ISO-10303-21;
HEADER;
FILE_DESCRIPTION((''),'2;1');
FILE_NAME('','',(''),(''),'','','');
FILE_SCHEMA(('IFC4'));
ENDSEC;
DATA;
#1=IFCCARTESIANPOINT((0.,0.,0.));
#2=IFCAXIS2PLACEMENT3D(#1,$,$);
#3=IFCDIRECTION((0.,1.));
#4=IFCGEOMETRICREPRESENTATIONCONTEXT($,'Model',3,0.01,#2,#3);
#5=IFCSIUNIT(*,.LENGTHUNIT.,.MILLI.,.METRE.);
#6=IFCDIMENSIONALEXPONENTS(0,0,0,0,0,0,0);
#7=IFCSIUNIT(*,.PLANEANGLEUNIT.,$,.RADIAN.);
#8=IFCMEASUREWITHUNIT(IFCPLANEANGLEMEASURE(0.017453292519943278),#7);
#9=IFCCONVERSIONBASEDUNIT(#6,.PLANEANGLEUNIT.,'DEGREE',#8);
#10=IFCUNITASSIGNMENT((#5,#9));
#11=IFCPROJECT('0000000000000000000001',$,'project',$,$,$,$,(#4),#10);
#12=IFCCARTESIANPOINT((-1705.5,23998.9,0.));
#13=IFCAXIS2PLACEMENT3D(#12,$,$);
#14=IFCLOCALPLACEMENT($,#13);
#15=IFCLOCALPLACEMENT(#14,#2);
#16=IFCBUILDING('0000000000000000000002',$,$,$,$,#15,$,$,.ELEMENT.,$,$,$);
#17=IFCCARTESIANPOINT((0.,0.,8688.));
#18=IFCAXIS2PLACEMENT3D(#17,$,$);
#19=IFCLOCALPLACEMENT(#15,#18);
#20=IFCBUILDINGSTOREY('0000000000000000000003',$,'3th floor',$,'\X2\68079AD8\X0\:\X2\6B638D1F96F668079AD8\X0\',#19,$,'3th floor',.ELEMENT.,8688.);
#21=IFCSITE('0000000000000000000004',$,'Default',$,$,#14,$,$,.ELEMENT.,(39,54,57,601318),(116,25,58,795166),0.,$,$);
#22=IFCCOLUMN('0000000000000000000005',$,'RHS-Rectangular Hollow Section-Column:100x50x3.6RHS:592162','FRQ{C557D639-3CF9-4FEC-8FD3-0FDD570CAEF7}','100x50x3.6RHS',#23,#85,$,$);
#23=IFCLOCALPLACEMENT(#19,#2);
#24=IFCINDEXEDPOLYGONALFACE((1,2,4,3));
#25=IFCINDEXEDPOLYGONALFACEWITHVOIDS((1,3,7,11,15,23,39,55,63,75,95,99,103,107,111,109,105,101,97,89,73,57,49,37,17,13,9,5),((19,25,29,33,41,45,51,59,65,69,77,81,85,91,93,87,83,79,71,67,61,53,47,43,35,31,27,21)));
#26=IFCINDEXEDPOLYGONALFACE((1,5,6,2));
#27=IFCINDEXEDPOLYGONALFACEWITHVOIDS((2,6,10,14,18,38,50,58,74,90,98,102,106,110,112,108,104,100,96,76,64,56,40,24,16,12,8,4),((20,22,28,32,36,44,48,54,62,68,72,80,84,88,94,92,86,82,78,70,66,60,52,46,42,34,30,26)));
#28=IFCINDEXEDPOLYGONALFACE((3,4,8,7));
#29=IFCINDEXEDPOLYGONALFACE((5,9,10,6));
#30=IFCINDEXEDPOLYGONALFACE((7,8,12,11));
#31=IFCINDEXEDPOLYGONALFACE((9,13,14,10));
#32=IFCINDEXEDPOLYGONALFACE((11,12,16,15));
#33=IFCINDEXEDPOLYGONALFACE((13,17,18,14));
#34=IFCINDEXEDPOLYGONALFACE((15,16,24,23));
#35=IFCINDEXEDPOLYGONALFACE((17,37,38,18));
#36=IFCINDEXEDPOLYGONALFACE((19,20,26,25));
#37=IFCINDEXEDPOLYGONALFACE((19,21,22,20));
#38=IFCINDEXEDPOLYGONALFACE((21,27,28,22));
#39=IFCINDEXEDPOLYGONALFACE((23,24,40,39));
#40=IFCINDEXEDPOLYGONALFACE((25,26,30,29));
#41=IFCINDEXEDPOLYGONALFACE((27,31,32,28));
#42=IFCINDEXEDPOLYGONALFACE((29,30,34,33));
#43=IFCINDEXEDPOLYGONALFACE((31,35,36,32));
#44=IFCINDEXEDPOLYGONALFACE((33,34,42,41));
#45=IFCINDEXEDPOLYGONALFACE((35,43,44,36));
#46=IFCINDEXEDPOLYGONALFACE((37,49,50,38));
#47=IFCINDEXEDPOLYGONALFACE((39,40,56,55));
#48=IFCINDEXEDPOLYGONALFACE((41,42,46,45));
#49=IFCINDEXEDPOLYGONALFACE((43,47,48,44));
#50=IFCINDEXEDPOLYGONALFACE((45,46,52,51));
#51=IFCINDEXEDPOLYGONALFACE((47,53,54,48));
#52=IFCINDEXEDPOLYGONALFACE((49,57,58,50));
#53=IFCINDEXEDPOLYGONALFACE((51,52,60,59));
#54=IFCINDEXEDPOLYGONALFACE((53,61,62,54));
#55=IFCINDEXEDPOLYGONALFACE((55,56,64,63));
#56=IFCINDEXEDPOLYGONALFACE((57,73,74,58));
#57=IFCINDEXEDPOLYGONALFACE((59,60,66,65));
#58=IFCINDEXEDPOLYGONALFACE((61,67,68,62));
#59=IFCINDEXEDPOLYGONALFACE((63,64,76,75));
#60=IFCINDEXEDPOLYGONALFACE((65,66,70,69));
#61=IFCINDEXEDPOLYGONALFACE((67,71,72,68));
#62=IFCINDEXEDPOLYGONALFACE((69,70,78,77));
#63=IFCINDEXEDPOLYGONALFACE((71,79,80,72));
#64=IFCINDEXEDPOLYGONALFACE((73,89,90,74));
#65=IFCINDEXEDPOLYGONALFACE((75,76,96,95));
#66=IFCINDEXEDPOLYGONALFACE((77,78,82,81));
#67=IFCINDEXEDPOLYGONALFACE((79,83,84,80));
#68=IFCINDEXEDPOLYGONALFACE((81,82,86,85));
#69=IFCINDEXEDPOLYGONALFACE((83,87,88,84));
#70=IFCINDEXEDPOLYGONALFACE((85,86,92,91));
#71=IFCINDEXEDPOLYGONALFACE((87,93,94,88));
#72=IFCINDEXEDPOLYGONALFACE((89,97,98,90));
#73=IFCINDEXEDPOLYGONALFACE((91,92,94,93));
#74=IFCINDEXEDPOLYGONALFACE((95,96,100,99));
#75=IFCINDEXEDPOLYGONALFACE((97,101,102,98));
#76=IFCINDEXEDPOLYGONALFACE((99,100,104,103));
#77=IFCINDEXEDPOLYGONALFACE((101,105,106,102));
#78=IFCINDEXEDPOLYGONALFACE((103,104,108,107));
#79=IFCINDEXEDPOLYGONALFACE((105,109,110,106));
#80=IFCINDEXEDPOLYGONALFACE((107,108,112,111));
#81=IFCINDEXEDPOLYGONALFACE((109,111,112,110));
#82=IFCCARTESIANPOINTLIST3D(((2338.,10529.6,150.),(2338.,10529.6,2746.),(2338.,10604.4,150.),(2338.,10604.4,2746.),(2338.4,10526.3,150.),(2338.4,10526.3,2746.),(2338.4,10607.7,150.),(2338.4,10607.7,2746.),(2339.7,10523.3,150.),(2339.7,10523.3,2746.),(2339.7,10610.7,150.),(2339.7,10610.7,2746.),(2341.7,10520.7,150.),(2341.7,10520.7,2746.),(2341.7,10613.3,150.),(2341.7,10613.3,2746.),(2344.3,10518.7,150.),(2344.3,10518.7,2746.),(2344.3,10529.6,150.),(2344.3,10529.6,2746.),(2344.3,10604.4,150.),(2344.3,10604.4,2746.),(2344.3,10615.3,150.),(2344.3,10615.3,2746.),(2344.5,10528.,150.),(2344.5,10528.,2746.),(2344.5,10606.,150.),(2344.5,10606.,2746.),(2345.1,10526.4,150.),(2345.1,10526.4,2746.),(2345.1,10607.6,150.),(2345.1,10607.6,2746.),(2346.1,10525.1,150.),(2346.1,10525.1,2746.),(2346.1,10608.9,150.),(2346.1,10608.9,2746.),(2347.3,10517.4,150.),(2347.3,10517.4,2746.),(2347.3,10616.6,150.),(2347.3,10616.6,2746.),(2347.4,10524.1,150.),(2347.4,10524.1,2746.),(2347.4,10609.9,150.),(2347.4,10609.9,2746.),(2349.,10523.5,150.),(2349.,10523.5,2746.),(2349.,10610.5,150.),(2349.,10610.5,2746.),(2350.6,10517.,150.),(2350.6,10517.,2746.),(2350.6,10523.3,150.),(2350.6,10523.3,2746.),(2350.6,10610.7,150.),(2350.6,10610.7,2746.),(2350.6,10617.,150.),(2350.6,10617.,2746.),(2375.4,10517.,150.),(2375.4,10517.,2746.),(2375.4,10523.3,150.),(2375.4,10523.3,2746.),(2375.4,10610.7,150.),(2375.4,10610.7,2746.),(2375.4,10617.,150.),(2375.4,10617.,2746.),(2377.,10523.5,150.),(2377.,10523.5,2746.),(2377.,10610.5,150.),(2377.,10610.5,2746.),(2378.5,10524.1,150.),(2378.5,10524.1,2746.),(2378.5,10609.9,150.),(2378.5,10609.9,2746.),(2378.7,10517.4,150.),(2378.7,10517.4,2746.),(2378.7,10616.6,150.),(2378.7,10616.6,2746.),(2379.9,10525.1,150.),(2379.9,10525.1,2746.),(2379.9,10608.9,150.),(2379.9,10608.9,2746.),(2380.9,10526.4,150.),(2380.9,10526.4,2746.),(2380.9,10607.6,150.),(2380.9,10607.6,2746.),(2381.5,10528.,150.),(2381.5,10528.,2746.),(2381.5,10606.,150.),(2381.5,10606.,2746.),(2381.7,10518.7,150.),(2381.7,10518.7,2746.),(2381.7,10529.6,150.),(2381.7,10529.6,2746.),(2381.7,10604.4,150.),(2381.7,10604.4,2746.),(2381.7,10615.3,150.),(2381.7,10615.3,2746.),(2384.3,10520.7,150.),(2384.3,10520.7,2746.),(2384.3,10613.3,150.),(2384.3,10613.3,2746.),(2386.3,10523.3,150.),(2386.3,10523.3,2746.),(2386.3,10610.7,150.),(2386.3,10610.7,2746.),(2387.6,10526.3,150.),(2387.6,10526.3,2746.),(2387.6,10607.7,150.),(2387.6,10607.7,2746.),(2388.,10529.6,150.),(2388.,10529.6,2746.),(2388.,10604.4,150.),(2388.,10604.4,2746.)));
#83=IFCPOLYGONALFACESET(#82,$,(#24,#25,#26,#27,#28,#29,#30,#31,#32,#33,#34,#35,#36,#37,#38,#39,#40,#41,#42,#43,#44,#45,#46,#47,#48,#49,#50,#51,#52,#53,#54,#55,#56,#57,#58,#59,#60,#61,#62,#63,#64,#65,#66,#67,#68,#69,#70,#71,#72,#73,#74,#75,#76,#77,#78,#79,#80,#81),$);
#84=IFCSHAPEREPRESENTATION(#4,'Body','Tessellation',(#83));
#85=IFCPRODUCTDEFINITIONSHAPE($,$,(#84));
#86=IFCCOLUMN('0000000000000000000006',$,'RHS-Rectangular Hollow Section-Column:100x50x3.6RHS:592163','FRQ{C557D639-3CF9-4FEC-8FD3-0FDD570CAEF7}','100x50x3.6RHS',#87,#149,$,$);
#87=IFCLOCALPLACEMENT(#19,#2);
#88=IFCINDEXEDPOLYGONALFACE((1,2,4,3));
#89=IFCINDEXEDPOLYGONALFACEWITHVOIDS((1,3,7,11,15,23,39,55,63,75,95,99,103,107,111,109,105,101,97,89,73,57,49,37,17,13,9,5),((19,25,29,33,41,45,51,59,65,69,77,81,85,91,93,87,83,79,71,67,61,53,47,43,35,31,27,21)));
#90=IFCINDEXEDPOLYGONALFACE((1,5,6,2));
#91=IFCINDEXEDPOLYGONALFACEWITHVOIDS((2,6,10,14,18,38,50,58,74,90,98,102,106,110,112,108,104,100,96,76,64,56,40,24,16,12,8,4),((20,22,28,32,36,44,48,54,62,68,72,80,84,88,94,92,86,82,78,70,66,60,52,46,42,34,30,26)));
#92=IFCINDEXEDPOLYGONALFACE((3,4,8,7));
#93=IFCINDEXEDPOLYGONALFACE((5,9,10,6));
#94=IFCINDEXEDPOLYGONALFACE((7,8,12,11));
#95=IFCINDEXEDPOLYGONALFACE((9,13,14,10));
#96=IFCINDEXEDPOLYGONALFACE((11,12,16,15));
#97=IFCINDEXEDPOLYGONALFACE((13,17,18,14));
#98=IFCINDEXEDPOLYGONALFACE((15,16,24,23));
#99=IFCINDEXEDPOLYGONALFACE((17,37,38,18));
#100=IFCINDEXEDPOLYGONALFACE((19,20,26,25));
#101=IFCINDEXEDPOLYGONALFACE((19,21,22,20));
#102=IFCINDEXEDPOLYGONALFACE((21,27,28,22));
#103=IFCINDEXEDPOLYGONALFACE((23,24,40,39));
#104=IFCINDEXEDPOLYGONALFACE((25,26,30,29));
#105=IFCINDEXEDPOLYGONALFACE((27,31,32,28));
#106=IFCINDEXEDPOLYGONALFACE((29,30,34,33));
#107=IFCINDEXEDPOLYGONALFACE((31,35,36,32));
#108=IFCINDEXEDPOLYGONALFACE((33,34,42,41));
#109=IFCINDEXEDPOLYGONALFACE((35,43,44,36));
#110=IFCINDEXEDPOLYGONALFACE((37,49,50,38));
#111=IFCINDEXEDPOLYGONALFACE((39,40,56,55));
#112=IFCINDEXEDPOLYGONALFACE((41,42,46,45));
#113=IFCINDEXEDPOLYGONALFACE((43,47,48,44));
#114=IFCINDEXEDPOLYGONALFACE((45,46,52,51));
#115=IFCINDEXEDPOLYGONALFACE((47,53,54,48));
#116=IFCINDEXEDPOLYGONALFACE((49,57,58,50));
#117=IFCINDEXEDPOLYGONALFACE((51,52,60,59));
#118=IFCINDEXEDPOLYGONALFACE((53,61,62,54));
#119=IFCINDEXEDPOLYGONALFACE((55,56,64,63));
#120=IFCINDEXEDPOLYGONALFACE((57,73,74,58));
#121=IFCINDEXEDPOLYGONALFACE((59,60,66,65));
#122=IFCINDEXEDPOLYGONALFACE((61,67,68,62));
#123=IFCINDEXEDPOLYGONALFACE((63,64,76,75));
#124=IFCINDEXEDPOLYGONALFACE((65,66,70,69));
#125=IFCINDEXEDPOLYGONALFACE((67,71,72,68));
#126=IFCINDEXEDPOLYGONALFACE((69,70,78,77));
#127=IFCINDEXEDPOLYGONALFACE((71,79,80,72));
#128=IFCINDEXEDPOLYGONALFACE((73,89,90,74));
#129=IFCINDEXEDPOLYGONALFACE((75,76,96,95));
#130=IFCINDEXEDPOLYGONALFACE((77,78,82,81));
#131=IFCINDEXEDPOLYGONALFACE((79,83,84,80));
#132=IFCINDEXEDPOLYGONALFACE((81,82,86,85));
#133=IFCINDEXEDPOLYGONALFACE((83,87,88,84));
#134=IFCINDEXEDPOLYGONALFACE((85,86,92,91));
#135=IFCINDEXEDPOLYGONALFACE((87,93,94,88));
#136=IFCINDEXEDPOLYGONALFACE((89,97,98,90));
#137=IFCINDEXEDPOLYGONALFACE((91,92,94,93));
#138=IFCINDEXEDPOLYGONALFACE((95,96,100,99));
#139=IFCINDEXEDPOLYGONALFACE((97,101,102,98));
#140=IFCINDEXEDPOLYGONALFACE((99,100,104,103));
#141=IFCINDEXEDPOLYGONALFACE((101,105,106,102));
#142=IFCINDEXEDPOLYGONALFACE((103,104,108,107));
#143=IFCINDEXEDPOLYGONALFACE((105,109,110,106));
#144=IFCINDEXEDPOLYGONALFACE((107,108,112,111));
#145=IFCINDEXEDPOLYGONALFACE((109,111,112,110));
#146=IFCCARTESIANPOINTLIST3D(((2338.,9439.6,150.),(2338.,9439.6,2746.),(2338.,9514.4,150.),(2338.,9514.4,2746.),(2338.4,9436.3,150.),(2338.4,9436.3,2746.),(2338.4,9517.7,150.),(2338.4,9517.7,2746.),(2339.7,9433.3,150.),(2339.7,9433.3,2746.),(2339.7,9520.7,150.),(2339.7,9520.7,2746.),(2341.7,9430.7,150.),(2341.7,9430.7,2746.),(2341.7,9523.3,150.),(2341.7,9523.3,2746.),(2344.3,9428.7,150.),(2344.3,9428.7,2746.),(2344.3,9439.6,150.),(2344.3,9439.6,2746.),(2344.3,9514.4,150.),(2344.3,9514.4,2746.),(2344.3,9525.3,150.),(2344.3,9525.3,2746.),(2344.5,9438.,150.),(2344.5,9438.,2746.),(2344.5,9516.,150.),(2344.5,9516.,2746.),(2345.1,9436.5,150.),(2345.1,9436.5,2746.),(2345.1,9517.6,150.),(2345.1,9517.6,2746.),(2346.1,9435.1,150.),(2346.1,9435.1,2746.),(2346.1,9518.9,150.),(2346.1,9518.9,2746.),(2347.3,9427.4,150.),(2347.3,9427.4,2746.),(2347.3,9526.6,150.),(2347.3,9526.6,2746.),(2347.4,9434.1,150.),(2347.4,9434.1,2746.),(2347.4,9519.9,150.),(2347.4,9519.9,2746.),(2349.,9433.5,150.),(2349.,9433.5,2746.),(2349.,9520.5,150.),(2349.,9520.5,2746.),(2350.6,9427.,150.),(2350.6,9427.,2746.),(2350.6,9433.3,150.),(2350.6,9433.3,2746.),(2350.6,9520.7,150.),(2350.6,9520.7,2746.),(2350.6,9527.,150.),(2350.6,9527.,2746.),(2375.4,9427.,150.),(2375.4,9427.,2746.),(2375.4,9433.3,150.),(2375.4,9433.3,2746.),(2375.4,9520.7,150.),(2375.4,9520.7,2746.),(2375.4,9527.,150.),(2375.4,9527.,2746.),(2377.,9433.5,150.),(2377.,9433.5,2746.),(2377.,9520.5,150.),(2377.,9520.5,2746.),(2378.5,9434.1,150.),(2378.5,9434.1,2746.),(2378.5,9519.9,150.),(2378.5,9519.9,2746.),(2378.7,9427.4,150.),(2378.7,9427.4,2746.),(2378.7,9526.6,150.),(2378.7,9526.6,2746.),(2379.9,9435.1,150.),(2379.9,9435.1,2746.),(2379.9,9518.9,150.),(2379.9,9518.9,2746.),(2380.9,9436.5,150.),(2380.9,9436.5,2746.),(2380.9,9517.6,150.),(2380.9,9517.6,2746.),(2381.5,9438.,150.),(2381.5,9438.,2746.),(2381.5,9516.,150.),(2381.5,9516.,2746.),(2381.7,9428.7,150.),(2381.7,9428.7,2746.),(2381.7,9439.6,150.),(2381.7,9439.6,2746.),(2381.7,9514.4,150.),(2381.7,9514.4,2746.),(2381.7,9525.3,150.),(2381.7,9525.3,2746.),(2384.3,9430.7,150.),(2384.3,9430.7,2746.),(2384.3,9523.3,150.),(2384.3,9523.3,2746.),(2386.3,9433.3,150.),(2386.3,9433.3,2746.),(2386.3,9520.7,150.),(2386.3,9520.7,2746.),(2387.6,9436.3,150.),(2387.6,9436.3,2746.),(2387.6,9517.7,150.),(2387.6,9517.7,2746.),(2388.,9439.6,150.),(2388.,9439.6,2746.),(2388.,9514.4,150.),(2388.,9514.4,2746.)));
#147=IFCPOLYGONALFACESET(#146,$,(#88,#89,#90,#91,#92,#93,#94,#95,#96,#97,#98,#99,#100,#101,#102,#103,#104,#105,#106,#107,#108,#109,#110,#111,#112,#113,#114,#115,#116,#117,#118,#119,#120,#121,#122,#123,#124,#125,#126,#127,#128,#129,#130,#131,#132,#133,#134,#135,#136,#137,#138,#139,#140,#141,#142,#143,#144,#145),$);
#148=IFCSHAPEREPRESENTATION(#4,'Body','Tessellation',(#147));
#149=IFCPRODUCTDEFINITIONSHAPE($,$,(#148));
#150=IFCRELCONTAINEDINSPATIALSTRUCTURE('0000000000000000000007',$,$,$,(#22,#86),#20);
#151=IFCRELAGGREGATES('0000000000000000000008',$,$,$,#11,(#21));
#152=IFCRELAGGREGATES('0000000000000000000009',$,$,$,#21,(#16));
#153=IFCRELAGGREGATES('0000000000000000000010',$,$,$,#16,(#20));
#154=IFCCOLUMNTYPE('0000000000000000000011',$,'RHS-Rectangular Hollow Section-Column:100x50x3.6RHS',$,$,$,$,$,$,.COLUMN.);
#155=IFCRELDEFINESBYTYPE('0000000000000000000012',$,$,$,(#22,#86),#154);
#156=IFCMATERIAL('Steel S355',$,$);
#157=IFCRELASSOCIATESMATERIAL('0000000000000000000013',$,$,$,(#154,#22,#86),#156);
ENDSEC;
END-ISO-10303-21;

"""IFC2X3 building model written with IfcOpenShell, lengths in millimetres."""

from ifc_helpers import new_model, entity, si_unit, converted_unit, direction, frame, origin, origin_2d, place, context, project, spatial, hollow_rectangle, extrude, clip, halfspace, material, type_object, element, save


model = new_model("IFC2X3")

# Units and contexts
model_context = context("Model", 3, precision=0.01, world=origin(), true_north=direction((0.0, 1.0)))
ifc_project = project(units=[si_unit("LENGTHUNIT", "METRE", prefix="MILLI"), converted_unit("PLANEANGLEUNIT", "DEGREE", entity("IfcPlaneAngleMeasure", 0.017453292519943278), si_unit("PLANEANGLEUNIT", "RADIAN"), dimensions=[0, 0, 0, 0, 0, 0, 0])], contexts=[model_context])

# Site, building, storey
site_placement = place(None, frame((-1705.5, 23998.9, 0.0)))
site = spatial("IfcSite", under=ifc_project, at=site_placement, Name="Default", CompositionType="ELEMENT", RefLatitude=(39, 54, 57, 601318), RefLongitude=(116, 25, 58, 795166), RefElevation=0.0)
building_placement = place(site_placement, origin())
building = spatial("IfcBuilding", under=site, at=building_placement, CompositionType="ELEMENT")
storey_placement = place(building_placement, frame((0.0, 0.0, 8688.0)))
storey = spatial("IfcBuildingStorey", under=building, at=storey_placement, Name="3th floor", ObjectType="标高:正负零标高", LongName="3th floor", CompositionType="ELEMENT", Elevation=8688.0)

# Shared definitions
ifc_material_1 = material(Name="Steel S355")

# Columns
column_type_1 = type_object("IfcColumnType", Name="RHS-Rectangular Hollow Section-Column:100x50x3.6RHS", PredefinedType="COLUMN", material=ifc_material_1)
column_1_placement = place(storey_placement, frame((2363.0, 10567.0, 2746.0), z_axis=(0.0, 0.0, 1.0), x_axis=(-1.0, 0.0, 0.0)))
element("IfcColumn", 1, at=column_1_placement, inside=storey, type_object=column_type_1, material=ifc_material_1, Name="RHS-Rectangular Hollow Section-Column:100x50x3.6RHS:592162", Description="FRQ{C557D639-3CF9-4FEC-8FD3-0FDD570CAEF7}", ObjectType="100x50x3.6RHS", context=model_context, shape_type="Clipping", body=[
    clip(extrude(hollow_rectangle(XDim=50.0, YDim=100.0, WallThickness=6.3, InnerFilletRadius=6.3, OuterFilletRadius=12.6, at=origin_2d()), origin(), (0.0, 0.0, -1.0), 2651.9), halfspace(frame((2363.0, 10567.0, -2596.0), z_axis=(0.0, 0.0, 1.0), x_axis=(-1.0, 0.0, 0.0)), True)),
])
column_2_placement = place(storey_placement, frame((2363.0, 9477.0, 2746.0), z_axis=(0.0, 0.0, 1.0), x_axis=(-1.0, 0.0, 0.0)))
element("IfcColumn", 2, at=column_2_placement, inside=storey, type_object=column_type_1, material=ifc_material_1, Name="RHS-Rectangular Hollow Section-Column:100x50x3.6RHS:592163", Description="FRQ{C557D639-3CF9-4FEC-8FD3-0FDD570CAEF7}", ObjectType="100x50x3.6RHS", context=model_context, shape_type="Clipping", body=[
    clip(extrude(hollow_rectangle(XDim=50.0, YDim=100.0, WallThickness=6.3, InnerFilletRadius=6.3, OuterFilletRadius=12.6, at=origin_2d()), origin(), (0.0, 0.0, -1.0), 2651.9), halfspace(frame((2363.0, 9477.0, -2596.0), z_axis=(0.0, 0.0, 1.0), x_axis=(-1.0, 0.0, 0.0)), True)),
])

save(model, "model.ifc")
